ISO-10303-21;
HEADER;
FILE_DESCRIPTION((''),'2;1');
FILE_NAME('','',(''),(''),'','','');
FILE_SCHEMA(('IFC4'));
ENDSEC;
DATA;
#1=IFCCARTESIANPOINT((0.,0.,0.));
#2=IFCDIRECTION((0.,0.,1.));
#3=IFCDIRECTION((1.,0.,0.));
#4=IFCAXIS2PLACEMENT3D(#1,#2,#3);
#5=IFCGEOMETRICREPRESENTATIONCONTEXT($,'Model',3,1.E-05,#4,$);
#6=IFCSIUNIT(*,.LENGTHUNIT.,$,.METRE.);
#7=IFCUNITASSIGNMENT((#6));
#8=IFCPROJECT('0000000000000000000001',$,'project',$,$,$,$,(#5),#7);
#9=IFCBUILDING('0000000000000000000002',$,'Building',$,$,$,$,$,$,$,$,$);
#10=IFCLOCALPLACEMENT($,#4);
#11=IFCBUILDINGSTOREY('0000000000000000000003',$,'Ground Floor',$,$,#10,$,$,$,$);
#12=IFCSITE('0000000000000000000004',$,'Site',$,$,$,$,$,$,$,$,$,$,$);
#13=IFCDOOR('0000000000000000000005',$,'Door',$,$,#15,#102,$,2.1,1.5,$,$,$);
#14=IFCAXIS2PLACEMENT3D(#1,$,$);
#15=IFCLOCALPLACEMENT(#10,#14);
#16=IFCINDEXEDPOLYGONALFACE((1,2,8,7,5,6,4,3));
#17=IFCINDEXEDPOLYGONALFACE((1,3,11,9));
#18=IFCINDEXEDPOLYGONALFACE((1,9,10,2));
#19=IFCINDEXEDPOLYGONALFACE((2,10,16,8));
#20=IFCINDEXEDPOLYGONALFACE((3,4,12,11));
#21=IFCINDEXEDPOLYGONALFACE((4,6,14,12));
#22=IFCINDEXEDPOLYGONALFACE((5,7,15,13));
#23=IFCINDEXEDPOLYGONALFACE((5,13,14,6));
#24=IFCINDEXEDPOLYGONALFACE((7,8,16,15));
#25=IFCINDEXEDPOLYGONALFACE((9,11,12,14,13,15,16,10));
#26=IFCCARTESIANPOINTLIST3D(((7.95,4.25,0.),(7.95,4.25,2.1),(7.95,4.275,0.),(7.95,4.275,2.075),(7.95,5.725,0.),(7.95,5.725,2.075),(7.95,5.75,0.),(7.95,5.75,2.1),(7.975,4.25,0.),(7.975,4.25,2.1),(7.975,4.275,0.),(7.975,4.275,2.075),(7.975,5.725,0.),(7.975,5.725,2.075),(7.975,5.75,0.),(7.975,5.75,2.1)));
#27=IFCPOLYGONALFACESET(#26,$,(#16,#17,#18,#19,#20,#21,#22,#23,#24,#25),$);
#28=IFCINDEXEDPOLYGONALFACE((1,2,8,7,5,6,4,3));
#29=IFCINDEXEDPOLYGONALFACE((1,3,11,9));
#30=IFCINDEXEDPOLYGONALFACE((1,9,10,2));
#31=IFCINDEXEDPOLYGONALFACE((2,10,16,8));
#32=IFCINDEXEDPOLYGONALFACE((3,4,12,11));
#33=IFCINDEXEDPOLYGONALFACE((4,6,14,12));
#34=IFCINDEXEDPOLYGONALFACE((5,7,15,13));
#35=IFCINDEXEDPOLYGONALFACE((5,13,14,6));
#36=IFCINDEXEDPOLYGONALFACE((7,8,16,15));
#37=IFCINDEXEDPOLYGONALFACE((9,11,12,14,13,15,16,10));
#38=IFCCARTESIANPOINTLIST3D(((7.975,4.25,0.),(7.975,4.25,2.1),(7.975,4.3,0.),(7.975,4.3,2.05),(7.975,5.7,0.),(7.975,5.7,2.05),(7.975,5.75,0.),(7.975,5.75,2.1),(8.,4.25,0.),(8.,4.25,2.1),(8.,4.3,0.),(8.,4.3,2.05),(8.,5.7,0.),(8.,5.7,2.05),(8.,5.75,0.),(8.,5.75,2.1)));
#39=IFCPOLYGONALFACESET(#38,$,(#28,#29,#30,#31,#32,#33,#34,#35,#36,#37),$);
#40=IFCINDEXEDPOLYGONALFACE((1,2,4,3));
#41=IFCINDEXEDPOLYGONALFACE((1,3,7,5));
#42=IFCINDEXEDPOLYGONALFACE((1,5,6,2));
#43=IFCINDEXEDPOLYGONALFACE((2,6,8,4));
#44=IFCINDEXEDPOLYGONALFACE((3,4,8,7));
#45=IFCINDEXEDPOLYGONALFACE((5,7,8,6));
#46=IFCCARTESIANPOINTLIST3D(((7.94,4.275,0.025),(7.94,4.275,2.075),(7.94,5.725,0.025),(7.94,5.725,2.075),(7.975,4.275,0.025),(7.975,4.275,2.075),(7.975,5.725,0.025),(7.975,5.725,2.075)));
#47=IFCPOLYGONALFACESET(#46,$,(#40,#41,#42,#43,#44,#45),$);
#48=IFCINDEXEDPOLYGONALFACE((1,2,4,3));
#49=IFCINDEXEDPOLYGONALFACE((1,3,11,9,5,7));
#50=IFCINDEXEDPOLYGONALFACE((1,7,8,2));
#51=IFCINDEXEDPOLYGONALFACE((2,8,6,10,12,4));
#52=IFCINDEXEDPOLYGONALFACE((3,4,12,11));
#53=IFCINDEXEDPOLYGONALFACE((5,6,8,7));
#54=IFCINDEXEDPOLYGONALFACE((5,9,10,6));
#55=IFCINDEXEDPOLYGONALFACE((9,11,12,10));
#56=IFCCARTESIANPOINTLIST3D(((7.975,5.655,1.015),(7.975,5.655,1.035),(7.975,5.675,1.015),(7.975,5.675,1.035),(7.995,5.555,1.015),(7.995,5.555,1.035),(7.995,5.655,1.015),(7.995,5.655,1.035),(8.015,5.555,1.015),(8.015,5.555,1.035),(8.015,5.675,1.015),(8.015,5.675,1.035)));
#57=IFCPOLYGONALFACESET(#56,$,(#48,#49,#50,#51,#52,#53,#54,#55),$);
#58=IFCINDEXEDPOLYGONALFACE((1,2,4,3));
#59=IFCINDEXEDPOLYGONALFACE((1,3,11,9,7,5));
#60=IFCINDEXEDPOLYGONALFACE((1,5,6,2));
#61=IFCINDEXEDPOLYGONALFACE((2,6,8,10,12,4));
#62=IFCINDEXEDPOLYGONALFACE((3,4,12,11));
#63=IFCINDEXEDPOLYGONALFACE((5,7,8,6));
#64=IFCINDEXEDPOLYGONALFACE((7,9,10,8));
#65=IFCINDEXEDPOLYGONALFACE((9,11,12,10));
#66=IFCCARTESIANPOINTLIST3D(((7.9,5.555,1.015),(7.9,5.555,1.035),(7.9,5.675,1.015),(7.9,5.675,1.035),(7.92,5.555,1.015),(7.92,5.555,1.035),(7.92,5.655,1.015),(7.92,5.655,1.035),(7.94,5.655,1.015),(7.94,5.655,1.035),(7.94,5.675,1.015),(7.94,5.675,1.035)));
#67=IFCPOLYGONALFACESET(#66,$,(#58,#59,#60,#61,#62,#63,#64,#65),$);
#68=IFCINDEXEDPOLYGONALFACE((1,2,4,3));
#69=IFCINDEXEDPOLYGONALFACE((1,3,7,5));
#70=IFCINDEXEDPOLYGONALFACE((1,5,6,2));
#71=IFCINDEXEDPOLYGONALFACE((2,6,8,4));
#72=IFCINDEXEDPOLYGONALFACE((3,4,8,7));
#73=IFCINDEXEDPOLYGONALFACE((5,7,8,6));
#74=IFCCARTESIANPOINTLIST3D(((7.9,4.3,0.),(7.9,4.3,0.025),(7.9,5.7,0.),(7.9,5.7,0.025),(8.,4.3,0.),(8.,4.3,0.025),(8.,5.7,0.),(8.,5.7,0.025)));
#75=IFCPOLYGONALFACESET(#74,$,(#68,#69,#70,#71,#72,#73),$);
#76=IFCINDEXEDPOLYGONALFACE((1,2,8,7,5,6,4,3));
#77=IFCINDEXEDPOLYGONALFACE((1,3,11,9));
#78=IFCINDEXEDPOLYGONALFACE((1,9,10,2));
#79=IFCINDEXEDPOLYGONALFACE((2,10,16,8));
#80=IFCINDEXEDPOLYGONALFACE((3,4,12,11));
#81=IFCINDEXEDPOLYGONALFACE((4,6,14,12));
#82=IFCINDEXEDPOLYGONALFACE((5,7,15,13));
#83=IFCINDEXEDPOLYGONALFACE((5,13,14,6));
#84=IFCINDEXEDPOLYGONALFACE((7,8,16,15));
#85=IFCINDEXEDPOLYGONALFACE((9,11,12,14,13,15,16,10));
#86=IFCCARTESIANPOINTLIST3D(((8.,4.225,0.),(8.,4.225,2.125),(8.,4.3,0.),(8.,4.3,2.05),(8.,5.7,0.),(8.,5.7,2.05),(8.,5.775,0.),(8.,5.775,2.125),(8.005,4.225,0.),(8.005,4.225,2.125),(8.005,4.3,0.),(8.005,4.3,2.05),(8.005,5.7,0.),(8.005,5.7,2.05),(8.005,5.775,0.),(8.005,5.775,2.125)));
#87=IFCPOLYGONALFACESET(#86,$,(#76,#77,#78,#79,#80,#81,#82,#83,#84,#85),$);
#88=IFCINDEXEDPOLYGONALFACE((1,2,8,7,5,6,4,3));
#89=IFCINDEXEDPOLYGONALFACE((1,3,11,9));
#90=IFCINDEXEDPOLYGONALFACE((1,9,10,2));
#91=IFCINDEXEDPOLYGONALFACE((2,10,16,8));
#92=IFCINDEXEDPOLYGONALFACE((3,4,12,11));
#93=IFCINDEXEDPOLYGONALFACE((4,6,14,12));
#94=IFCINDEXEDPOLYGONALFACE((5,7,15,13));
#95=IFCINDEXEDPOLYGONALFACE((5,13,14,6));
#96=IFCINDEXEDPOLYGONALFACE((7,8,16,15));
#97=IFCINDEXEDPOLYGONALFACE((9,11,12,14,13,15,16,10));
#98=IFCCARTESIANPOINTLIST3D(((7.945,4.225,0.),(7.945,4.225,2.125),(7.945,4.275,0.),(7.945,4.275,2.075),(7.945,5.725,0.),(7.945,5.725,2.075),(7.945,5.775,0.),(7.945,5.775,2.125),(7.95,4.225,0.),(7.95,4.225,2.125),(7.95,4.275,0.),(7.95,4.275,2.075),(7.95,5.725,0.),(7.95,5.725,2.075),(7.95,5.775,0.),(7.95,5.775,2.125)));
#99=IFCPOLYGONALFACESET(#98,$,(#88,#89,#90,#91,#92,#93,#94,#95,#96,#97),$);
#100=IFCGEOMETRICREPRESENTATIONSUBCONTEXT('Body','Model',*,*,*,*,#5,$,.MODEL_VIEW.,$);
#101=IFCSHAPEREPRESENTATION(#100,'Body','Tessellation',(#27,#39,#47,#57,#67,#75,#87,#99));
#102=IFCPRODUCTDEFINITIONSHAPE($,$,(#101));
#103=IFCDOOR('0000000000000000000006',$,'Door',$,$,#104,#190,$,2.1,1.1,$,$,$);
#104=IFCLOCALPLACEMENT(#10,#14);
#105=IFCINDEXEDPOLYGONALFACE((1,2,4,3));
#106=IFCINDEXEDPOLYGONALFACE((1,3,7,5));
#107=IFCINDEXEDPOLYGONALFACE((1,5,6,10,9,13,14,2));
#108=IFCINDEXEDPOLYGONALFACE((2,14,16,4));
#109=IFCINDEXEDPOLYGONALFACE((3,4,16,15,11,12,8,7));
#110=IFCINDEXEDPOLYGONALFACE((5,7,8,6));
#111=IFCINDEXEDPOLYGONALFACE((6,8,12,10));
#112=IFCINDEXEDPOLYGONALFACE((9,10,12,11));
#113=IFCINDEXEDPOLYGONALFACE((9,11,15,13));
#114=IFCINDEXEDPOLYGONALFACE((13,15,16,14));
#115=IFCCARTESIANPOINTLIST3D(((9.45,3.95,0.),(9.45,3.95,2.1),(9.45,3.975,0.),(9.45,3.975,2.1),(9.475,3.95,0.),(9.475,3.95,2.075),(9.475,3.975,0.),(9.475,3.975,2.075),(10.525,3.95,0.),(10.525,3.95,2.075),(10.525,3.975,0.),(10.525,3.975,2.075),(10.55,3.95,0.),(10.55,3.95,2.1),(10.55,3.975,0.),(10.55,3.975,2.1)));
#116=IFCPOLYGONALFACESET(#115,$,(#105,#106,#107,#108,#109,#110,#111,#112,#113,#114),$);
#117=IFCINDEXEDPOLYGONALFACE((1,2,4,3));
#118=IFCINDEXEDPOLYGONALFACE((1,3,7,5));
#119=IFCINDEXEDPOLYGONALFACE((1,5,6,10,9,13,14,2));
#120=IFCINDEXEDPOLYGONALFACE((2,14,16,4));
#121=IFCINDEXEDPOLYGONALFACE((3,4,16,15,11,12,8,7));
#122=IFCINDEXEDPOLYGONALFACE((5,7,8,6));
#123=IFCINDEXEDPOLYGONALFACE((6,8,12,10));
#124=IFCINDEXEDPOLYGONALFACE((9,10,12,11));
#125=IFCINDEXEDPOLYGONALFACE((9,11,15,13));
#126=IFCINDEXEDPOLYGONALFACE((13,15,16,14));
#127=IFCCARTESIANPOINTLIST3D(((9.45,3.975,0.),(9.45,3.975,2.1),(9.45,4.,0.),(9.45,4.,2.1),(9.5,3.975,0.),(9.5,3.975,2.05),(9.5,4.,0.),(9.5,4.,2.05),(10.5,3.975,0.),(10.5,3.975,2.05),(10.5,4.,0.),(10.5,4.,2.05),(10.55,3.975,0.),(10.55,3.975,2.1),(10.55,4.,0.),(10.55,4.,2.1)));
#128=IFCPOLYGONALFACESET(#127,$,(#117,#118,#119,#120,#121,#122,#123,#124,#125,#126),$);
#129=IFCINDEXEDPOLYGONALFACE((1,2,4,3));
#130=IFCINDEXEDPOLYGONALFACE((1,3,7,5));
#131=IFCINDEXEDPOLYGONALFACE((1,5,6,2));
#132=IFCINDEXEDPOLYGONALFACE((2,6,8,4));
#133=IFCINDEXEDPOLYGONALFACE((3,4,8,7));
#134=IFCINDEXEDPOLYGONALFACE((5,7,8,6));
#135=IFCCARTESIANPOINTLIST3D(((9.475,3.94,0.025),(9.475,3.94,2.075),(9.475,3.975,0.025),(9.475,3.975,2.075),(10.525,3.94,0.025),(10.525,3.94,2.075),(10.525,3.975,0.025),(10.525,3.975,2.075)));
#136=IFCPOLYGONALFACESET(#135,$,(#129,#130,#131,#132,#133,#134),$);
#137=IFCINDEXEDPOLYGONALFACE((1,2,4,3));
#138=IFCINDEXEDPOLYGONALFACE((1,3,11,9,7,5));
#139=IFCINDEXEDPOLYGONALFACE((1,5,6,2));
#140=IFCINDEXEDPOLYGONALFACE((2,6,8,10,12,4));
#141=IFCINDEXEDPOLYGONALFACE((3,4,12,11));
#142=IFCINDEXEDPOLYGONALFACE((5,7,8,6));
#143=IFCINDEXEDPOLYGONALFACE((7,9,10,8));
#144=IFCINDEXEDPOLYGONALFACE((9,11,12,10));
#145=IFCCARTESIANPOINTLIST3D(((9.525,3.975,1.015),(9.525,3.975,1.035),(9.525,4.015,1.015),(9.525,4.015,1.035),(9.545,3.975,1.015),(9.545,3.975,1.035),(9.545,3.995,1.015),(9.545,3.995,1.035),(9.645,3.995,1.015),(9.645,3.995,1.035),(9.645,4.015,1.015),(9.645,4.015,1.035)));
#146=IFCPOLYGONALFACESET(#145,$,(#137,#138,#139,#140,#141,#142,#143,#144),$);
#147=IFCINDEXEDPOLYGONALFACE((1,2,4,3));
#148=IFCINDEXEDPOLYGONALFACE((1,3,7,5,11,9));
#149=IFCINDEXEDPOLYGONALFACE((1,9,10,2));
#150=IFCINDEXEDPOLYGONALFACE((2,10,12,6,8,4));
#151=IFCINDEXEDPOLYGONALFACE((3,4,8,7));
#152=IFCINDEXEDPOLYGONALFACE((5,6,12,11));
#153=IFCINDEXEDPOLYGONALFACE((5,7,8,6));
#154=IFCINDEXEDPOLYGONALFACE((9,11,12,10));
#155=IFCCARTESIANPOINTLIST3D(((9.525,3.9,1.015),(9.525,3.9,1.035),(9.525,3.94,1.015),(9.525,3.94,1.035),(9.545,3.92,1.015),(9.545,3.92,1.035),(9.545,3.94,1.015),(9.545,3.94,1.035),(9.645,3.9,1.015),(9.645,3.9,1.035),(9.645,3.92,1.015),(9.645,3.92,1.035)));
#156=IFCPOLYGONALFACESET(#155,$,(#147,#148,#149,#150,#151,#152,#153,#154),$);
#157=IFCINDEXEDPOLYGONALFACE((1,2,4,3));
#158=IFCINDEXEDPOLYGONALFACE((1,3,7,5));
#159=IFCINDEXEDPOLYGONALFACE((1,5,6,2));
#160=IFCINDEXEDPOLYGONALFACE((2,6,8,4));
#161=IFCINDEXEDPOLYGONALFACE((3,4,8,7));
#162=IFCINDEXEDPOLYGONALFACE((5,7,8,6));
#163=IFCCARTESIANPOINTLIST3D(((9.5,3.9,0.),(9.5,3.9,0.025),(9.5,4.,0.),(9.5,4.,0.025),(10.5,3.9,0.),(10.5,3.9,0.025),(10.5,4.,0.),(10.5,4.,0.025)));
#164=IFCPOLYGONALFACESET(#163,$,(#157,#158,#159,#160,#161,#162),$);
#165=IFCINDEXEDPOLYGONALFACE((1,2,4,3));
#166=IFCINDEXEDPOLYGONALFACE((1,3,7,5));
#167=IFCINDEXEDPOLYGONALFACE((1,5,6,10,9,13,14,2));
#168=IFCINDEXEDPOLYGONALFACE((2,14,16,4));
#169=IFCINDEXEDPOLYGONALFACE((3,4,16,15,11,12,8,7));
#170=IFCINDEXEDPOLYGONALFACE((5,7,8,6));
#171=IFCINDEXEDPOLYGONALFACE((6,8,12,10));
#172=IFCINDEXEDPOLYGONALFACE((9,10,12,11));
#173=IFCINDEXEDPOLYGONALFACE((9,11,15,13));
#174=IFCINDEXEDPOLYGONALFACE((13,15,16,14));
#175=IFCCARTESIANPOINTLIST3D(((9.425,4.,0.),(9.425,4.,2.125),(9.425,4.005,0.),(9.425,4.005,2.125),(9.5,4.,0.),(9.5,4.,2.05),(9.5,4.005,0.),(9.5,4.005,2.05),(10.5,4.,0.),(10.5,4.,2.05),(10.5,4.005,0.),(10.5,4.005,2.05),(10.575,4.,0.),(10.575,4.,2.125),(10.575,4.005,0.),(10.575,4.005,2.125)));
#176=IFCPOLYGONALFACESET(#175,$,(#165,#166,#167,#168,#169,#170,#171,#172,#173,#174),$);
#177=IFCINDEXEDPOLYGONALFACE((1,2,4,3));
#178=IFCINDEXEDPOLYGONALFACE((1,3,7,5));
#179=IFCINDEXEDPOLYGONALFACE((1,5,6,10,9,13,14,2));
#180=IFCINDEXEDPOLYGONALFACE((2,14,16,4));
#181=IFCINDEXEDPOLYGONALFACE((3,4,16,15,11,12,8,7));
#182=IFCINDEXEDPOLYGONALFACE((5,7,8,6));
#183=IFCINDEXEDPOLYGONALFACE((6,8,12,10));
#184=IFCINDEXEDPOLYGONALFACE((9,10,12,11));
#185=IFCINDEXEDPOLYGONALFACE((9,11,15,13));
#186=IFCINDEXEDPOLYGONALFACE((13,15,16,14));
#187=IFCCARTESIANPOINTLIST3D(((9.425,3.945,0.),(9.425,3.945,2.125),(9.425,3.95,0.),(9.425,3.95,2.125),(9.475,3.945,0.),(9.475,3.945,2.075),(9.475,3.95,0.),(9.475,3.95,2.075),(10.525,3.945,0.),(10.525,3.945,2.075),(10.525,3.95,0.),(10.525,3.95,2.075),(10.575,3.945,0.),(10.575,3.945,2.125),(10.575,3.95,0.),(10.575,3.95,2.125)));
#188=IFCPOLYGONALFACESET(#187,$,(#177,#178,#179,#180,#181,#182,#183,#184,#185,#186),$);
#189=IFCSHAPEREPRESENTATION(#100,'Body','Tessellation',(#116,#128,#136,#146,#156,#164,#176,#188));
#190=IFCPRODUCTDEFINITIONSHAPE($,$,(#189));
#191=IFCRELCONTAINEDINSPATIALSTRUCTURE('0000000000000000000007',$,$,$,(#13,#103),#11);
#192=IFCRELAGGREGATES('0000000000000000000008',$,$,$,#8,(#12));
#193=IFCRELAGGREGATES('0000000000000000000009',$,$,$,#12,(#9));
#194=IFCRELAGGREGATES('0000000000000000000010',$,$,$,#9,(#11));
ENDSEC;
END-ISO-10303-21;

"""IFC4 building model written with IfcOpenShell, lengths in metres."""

from ifc_helpers import new_model, si_unit, frame, origin_with_axes, place, context, subcontext, project, spatial, line, indexed_curve, outline, extrude, element, save


model = new_model("IFC4")

# Units and contexts
model_context = context("Model", 3, precision=1e-05, world=origin_with_axes())
body_context = subcontext(model_context, "Body", "Model", "MODEL_VIEW")
ifc_project = project(units=[si_unit("LENGTHUNIT", "METRE")], contexts=[model_context])

# Site, building, storey
site = spatial("IfcSite", under=ifc_project, Name="Site")
building = spatial("IfcBuilding", under=site, Name="Building")
storey_placement = place(None, origin_with_axes())
storey = spatial("IfcBuildingStorey", under=building, at=storey_placement, Name="Ground Floor")

# Doors
door_1_placement = place(storey_placement, frame((8.0, 4.25, 0.0), z_axis=(0.0, 0.0, 1.0), x_axis=(0.0, 1.0, 0.0)))
element("IfcDoor", 1, at=door_1_placement, inside=storey, Name="Door", OverallHeight=2.1, OverallWidth=1.5, context=body_context, shape_type="SweptSolid", body=[
    extrude(outline(indexed_curve([(0.0, 0.0), (0.0, 2.1), (1.5, 2.1), (1.5, 0.0), (1.475, 0.0), (1.475, 2.075), (0.025, 2.075), (0.025, 0.0)], segments=[line(1, 2, 3, 4, 5, 6, 7, 8, 1)])), frame((0.0, 0.025, 0.0), z_axis=(0.0, -1.0, 0.0), x_axis=(1.0, 0.0, 0.0)), (0.0, 0.0, -1.0), 0.025),
    extrude(outline(indexed_curve([(0.0, 0.0), (0.0, 2.1), (1.5, 2.1), (1.5, 0.0), (1.45, 0.0), (1.45, 2.05), (0.05, 2.05), (0.05, 0.0)], segments=[line(1, 2, 3, 4, 5, 6, 7, 8, 1)])), frame((0.0, 0.0, 0.0), z_axis=(0.0, -1.0, 0.0), x_axis=(1.0, 0.0, 0.0)), (0.0, 0.0, -1.0), 0.025),
    extrude(outline(indexed_curve([(0.0, 0.0), (1.45, 0.0), (1.45, 0.035), (0.0, 0.035)], segments=[line(1, 2, 3, 4, 1)])), frame((0.025, 0.025, 0.025), z_axis=(0.0, 0.0, 1.0), x_axis=(1.0, 0.0, 0.0)), (0.0, 0.0, 1.0), 2.05),
    extrude(outline(indexed_curve([(0.0, 0.0), (0.0, -0.04), (-0.12, -0.04), (-0.12, -0.02), (-0.02, -0.02), (-0.02, 0.0)], segments=[line(1, 2, 3, 4, 5, 6, 1)])), frame((1.425, 0.025, 1.015), z_axis=(0.0, 0.0, 1.0), x_axis=(1.0, 0.0, 0.0)), (0.0, 0.0, 1.0), 0.02),
    extrude(outline(indexed_curve([(0.0, 0.0), (0.0, 0.04), (-0.12, 0.04), (-0.12, 0.02), (-0.02, 0.02), (-0.02, 0.0)], segments=[line(1, 2, 3, 4, 5, 6, 1)])), frame((1.425, 0.06, 1.015), z_axis=(0.0, 0.0, 1.0), x_axis=(1.0, 0.0, 0.0)), (0.0, 0.0, 1.0), 0.02),
    extrude(outline(indexed_curve([(0.0, 0.0), (1.4, 0.0), (1.4, 0.1), (0.0, 0.1)], segments=[line(1, 2, 3, 4, 1)])), frame((0.05, 0.0, 0.0), z_axis=(0.0, 0.0, 1.0), x_axis=(1.0, 0.0, 0.0)), (0.0, 0.0, 1.0), 0.025),
    extrude(outline(indexed_curve([(0.0, 0.0), (0.0, 2.125), (1.55, 2.125), (1.55, 0.0), (1.475, 0.0), (1.475, 2.05), (0.075, 2.05), (0.075, 0.0)], segments=[line(1, 2, 3, 4, 5, 6, 7, 8, 1)])), frame((-0.025, -0.005, 0.0), z_axis=(0.0, -1.0, 0.0), x_axis=(1.0, 0.0, 0.0)), (0.0, 0.0, -1.0), 0.005),
    extrude(outline(indexed_curve([(0.0, 0.0), (0.0, 2.125), (1.55, 2.125), (1.55, 0.0), (1.5, 0.0), (1.5, 2.075), (0.05, 2.075), (0.05, 0.0)], segments=[line(1, 2, 3, 4, 5, 6, 7, 8, 1)])), frame((-0.025, 0.05, 0.0), z_axis=(0.0, -1.0, 0.0), x_axis=(1.0, 0.0, 0.0)), (0.0, 0.0, -1.0), 0.005),
])
door_2_placement = place(storey_placement, frame((10.55, 4.0, 0.0), z_axis=(0.0, 0.0, 1.0), x_axis=(-1.0, 0.0, 0.0)))
element("IfcDoor", 2, at=door_2_placement, inside=storey, Name="Door", OverallHeight=2.1, OverallWidth=1.1, context=body_context, shape_type="SweptSolid", body=[
    extrude(outline(indexed_curve([(0.0, 0.0), (0.0, 2.1), (1.1, 2.1), (1.1, 0.0), (1.075, 0.0), (1.075, 2.075), (0.025, 2.075), (0.025, 0.0)], segments=[line(1, 2, 3, 4, 5, 6, 7, 8, 1)])), frame((0.0, 0.025, 0.0), z_axis=(0.0, -1.0, 0.0), x_axis=(1.0, 0.0, 0.0)), (0.0, 0.0, -1.0), 0.025),
    extrude(outline(indexed_curve([(0.0, 0.0), (0.0, 2.1), (1.1, 2.1), (1.1, 0.0), (1.05, 0.0), (1.05, 2.05), (0.05, 2.05), (0.05, 0.0)], segments=[line(1, 2, 3, 4, 5, 6, 7, 8, 1)])), frame((0.0, 0.0, 0.0), z_axis=(0.0, -1.0, 0.0), x_axis=(1.0, 0.0, 0.0)), (0.0, 0.0, -1.0), 0.025),
    extrude(outline(indexed_curve([(0.0, 0.0), (1.05, 0.0), (1.05, 0.035), (0.0, 0.035)], segments=[line(1, 2, 3, 4, 1)])), frame((0.025, 0.025, 0.025), z_axis=(0.0, 0.0, 1.0), x_axis=(1.0, 0.0, 0.0)), (0.0, 0.0, 1.0), 2.05),
    extrude(outline(indexed_curve([(0.0, 0.0), (0.0, -0.04), (-0.12, -0.04), (-0.12, -0.02), (-0.02, -0.02), (-0.02, 0.0)], segments=[line(1, 2, 3, 4, 5, 6, 1)])), frame((1.025, 0.025, 1.015), z_axis=(0.0, 0.0, 1.0), x_axis=(1.0, 0.0, 0.0)), (0.0, 0.0, 1.0), 0.02),
    extrude(outline(indexed_curve([(0.0, 0.0), (0.0, 0.04), (-0.12, 0.04), (-0.12, 0.02), (-0.02, 0.02), (-0.02, 0.0)], segments=[line(1, 2, 3, 4, 5, 6, 1)])), frame((1.025, 0.06, 1.015), z_axis=(0.0, 0.0, 1.0), x_axis=(1.0, 0.0, 0.0)), (0.0, 0.0, 1.0), 0.02),
    extrude(outline(indexed_curve([(0.0, 0.0), (1.0, 0.0), (1.0, 0.1), (0.0, 0.1)], segments=[line(1, 2, 3, 4, 1)])), frame((0.05, 0.0, 0.0), z_axis=(0.0, 0.0, 1.0), x_axis=(1.0, 0.0, 0.0)), (0.0, 0.0, 1.0), 0.025),
    extrude(outline(indexed_curve([(0.0, 0.0), (0.0, 2.125), (1.15, 2.125), (1.15, 0.0), (1.075, 0.0), (1.075, 2.05), (0.075, 2.05), (0.075, 0.0)], segments=[line(1, 2, 3, 4, 5, 6, 7, 8, 1)])), frame((-0.025, -0.005, 0.0), z_axis=(0.0, -1.0, 0.0), x_axis=(1.0, 0.0, 0.0)), (0.0, 0.0, -1.0), 0.005),
    extrude(outline(indexed_curve([(0.0, 0.0), (0.0, 2.125), (1.15, 2.125), (1.15, 0.0), (1.1, 0.0), (1.1, 2.075), (0.05, 2.075), (0.05, 0.0)], segments=[line(1, 2, 3, 4, 5, 6, 7, 8, 1)])), frame((-0.025, 0.05, 0.0), z_axis=(0.0, -1.0, 0.0), x_axis=(1.0, 0.0, 0.0)), (0.0, 0.0, -1.0), 0.005),
])

save(model, "model.ifc")
